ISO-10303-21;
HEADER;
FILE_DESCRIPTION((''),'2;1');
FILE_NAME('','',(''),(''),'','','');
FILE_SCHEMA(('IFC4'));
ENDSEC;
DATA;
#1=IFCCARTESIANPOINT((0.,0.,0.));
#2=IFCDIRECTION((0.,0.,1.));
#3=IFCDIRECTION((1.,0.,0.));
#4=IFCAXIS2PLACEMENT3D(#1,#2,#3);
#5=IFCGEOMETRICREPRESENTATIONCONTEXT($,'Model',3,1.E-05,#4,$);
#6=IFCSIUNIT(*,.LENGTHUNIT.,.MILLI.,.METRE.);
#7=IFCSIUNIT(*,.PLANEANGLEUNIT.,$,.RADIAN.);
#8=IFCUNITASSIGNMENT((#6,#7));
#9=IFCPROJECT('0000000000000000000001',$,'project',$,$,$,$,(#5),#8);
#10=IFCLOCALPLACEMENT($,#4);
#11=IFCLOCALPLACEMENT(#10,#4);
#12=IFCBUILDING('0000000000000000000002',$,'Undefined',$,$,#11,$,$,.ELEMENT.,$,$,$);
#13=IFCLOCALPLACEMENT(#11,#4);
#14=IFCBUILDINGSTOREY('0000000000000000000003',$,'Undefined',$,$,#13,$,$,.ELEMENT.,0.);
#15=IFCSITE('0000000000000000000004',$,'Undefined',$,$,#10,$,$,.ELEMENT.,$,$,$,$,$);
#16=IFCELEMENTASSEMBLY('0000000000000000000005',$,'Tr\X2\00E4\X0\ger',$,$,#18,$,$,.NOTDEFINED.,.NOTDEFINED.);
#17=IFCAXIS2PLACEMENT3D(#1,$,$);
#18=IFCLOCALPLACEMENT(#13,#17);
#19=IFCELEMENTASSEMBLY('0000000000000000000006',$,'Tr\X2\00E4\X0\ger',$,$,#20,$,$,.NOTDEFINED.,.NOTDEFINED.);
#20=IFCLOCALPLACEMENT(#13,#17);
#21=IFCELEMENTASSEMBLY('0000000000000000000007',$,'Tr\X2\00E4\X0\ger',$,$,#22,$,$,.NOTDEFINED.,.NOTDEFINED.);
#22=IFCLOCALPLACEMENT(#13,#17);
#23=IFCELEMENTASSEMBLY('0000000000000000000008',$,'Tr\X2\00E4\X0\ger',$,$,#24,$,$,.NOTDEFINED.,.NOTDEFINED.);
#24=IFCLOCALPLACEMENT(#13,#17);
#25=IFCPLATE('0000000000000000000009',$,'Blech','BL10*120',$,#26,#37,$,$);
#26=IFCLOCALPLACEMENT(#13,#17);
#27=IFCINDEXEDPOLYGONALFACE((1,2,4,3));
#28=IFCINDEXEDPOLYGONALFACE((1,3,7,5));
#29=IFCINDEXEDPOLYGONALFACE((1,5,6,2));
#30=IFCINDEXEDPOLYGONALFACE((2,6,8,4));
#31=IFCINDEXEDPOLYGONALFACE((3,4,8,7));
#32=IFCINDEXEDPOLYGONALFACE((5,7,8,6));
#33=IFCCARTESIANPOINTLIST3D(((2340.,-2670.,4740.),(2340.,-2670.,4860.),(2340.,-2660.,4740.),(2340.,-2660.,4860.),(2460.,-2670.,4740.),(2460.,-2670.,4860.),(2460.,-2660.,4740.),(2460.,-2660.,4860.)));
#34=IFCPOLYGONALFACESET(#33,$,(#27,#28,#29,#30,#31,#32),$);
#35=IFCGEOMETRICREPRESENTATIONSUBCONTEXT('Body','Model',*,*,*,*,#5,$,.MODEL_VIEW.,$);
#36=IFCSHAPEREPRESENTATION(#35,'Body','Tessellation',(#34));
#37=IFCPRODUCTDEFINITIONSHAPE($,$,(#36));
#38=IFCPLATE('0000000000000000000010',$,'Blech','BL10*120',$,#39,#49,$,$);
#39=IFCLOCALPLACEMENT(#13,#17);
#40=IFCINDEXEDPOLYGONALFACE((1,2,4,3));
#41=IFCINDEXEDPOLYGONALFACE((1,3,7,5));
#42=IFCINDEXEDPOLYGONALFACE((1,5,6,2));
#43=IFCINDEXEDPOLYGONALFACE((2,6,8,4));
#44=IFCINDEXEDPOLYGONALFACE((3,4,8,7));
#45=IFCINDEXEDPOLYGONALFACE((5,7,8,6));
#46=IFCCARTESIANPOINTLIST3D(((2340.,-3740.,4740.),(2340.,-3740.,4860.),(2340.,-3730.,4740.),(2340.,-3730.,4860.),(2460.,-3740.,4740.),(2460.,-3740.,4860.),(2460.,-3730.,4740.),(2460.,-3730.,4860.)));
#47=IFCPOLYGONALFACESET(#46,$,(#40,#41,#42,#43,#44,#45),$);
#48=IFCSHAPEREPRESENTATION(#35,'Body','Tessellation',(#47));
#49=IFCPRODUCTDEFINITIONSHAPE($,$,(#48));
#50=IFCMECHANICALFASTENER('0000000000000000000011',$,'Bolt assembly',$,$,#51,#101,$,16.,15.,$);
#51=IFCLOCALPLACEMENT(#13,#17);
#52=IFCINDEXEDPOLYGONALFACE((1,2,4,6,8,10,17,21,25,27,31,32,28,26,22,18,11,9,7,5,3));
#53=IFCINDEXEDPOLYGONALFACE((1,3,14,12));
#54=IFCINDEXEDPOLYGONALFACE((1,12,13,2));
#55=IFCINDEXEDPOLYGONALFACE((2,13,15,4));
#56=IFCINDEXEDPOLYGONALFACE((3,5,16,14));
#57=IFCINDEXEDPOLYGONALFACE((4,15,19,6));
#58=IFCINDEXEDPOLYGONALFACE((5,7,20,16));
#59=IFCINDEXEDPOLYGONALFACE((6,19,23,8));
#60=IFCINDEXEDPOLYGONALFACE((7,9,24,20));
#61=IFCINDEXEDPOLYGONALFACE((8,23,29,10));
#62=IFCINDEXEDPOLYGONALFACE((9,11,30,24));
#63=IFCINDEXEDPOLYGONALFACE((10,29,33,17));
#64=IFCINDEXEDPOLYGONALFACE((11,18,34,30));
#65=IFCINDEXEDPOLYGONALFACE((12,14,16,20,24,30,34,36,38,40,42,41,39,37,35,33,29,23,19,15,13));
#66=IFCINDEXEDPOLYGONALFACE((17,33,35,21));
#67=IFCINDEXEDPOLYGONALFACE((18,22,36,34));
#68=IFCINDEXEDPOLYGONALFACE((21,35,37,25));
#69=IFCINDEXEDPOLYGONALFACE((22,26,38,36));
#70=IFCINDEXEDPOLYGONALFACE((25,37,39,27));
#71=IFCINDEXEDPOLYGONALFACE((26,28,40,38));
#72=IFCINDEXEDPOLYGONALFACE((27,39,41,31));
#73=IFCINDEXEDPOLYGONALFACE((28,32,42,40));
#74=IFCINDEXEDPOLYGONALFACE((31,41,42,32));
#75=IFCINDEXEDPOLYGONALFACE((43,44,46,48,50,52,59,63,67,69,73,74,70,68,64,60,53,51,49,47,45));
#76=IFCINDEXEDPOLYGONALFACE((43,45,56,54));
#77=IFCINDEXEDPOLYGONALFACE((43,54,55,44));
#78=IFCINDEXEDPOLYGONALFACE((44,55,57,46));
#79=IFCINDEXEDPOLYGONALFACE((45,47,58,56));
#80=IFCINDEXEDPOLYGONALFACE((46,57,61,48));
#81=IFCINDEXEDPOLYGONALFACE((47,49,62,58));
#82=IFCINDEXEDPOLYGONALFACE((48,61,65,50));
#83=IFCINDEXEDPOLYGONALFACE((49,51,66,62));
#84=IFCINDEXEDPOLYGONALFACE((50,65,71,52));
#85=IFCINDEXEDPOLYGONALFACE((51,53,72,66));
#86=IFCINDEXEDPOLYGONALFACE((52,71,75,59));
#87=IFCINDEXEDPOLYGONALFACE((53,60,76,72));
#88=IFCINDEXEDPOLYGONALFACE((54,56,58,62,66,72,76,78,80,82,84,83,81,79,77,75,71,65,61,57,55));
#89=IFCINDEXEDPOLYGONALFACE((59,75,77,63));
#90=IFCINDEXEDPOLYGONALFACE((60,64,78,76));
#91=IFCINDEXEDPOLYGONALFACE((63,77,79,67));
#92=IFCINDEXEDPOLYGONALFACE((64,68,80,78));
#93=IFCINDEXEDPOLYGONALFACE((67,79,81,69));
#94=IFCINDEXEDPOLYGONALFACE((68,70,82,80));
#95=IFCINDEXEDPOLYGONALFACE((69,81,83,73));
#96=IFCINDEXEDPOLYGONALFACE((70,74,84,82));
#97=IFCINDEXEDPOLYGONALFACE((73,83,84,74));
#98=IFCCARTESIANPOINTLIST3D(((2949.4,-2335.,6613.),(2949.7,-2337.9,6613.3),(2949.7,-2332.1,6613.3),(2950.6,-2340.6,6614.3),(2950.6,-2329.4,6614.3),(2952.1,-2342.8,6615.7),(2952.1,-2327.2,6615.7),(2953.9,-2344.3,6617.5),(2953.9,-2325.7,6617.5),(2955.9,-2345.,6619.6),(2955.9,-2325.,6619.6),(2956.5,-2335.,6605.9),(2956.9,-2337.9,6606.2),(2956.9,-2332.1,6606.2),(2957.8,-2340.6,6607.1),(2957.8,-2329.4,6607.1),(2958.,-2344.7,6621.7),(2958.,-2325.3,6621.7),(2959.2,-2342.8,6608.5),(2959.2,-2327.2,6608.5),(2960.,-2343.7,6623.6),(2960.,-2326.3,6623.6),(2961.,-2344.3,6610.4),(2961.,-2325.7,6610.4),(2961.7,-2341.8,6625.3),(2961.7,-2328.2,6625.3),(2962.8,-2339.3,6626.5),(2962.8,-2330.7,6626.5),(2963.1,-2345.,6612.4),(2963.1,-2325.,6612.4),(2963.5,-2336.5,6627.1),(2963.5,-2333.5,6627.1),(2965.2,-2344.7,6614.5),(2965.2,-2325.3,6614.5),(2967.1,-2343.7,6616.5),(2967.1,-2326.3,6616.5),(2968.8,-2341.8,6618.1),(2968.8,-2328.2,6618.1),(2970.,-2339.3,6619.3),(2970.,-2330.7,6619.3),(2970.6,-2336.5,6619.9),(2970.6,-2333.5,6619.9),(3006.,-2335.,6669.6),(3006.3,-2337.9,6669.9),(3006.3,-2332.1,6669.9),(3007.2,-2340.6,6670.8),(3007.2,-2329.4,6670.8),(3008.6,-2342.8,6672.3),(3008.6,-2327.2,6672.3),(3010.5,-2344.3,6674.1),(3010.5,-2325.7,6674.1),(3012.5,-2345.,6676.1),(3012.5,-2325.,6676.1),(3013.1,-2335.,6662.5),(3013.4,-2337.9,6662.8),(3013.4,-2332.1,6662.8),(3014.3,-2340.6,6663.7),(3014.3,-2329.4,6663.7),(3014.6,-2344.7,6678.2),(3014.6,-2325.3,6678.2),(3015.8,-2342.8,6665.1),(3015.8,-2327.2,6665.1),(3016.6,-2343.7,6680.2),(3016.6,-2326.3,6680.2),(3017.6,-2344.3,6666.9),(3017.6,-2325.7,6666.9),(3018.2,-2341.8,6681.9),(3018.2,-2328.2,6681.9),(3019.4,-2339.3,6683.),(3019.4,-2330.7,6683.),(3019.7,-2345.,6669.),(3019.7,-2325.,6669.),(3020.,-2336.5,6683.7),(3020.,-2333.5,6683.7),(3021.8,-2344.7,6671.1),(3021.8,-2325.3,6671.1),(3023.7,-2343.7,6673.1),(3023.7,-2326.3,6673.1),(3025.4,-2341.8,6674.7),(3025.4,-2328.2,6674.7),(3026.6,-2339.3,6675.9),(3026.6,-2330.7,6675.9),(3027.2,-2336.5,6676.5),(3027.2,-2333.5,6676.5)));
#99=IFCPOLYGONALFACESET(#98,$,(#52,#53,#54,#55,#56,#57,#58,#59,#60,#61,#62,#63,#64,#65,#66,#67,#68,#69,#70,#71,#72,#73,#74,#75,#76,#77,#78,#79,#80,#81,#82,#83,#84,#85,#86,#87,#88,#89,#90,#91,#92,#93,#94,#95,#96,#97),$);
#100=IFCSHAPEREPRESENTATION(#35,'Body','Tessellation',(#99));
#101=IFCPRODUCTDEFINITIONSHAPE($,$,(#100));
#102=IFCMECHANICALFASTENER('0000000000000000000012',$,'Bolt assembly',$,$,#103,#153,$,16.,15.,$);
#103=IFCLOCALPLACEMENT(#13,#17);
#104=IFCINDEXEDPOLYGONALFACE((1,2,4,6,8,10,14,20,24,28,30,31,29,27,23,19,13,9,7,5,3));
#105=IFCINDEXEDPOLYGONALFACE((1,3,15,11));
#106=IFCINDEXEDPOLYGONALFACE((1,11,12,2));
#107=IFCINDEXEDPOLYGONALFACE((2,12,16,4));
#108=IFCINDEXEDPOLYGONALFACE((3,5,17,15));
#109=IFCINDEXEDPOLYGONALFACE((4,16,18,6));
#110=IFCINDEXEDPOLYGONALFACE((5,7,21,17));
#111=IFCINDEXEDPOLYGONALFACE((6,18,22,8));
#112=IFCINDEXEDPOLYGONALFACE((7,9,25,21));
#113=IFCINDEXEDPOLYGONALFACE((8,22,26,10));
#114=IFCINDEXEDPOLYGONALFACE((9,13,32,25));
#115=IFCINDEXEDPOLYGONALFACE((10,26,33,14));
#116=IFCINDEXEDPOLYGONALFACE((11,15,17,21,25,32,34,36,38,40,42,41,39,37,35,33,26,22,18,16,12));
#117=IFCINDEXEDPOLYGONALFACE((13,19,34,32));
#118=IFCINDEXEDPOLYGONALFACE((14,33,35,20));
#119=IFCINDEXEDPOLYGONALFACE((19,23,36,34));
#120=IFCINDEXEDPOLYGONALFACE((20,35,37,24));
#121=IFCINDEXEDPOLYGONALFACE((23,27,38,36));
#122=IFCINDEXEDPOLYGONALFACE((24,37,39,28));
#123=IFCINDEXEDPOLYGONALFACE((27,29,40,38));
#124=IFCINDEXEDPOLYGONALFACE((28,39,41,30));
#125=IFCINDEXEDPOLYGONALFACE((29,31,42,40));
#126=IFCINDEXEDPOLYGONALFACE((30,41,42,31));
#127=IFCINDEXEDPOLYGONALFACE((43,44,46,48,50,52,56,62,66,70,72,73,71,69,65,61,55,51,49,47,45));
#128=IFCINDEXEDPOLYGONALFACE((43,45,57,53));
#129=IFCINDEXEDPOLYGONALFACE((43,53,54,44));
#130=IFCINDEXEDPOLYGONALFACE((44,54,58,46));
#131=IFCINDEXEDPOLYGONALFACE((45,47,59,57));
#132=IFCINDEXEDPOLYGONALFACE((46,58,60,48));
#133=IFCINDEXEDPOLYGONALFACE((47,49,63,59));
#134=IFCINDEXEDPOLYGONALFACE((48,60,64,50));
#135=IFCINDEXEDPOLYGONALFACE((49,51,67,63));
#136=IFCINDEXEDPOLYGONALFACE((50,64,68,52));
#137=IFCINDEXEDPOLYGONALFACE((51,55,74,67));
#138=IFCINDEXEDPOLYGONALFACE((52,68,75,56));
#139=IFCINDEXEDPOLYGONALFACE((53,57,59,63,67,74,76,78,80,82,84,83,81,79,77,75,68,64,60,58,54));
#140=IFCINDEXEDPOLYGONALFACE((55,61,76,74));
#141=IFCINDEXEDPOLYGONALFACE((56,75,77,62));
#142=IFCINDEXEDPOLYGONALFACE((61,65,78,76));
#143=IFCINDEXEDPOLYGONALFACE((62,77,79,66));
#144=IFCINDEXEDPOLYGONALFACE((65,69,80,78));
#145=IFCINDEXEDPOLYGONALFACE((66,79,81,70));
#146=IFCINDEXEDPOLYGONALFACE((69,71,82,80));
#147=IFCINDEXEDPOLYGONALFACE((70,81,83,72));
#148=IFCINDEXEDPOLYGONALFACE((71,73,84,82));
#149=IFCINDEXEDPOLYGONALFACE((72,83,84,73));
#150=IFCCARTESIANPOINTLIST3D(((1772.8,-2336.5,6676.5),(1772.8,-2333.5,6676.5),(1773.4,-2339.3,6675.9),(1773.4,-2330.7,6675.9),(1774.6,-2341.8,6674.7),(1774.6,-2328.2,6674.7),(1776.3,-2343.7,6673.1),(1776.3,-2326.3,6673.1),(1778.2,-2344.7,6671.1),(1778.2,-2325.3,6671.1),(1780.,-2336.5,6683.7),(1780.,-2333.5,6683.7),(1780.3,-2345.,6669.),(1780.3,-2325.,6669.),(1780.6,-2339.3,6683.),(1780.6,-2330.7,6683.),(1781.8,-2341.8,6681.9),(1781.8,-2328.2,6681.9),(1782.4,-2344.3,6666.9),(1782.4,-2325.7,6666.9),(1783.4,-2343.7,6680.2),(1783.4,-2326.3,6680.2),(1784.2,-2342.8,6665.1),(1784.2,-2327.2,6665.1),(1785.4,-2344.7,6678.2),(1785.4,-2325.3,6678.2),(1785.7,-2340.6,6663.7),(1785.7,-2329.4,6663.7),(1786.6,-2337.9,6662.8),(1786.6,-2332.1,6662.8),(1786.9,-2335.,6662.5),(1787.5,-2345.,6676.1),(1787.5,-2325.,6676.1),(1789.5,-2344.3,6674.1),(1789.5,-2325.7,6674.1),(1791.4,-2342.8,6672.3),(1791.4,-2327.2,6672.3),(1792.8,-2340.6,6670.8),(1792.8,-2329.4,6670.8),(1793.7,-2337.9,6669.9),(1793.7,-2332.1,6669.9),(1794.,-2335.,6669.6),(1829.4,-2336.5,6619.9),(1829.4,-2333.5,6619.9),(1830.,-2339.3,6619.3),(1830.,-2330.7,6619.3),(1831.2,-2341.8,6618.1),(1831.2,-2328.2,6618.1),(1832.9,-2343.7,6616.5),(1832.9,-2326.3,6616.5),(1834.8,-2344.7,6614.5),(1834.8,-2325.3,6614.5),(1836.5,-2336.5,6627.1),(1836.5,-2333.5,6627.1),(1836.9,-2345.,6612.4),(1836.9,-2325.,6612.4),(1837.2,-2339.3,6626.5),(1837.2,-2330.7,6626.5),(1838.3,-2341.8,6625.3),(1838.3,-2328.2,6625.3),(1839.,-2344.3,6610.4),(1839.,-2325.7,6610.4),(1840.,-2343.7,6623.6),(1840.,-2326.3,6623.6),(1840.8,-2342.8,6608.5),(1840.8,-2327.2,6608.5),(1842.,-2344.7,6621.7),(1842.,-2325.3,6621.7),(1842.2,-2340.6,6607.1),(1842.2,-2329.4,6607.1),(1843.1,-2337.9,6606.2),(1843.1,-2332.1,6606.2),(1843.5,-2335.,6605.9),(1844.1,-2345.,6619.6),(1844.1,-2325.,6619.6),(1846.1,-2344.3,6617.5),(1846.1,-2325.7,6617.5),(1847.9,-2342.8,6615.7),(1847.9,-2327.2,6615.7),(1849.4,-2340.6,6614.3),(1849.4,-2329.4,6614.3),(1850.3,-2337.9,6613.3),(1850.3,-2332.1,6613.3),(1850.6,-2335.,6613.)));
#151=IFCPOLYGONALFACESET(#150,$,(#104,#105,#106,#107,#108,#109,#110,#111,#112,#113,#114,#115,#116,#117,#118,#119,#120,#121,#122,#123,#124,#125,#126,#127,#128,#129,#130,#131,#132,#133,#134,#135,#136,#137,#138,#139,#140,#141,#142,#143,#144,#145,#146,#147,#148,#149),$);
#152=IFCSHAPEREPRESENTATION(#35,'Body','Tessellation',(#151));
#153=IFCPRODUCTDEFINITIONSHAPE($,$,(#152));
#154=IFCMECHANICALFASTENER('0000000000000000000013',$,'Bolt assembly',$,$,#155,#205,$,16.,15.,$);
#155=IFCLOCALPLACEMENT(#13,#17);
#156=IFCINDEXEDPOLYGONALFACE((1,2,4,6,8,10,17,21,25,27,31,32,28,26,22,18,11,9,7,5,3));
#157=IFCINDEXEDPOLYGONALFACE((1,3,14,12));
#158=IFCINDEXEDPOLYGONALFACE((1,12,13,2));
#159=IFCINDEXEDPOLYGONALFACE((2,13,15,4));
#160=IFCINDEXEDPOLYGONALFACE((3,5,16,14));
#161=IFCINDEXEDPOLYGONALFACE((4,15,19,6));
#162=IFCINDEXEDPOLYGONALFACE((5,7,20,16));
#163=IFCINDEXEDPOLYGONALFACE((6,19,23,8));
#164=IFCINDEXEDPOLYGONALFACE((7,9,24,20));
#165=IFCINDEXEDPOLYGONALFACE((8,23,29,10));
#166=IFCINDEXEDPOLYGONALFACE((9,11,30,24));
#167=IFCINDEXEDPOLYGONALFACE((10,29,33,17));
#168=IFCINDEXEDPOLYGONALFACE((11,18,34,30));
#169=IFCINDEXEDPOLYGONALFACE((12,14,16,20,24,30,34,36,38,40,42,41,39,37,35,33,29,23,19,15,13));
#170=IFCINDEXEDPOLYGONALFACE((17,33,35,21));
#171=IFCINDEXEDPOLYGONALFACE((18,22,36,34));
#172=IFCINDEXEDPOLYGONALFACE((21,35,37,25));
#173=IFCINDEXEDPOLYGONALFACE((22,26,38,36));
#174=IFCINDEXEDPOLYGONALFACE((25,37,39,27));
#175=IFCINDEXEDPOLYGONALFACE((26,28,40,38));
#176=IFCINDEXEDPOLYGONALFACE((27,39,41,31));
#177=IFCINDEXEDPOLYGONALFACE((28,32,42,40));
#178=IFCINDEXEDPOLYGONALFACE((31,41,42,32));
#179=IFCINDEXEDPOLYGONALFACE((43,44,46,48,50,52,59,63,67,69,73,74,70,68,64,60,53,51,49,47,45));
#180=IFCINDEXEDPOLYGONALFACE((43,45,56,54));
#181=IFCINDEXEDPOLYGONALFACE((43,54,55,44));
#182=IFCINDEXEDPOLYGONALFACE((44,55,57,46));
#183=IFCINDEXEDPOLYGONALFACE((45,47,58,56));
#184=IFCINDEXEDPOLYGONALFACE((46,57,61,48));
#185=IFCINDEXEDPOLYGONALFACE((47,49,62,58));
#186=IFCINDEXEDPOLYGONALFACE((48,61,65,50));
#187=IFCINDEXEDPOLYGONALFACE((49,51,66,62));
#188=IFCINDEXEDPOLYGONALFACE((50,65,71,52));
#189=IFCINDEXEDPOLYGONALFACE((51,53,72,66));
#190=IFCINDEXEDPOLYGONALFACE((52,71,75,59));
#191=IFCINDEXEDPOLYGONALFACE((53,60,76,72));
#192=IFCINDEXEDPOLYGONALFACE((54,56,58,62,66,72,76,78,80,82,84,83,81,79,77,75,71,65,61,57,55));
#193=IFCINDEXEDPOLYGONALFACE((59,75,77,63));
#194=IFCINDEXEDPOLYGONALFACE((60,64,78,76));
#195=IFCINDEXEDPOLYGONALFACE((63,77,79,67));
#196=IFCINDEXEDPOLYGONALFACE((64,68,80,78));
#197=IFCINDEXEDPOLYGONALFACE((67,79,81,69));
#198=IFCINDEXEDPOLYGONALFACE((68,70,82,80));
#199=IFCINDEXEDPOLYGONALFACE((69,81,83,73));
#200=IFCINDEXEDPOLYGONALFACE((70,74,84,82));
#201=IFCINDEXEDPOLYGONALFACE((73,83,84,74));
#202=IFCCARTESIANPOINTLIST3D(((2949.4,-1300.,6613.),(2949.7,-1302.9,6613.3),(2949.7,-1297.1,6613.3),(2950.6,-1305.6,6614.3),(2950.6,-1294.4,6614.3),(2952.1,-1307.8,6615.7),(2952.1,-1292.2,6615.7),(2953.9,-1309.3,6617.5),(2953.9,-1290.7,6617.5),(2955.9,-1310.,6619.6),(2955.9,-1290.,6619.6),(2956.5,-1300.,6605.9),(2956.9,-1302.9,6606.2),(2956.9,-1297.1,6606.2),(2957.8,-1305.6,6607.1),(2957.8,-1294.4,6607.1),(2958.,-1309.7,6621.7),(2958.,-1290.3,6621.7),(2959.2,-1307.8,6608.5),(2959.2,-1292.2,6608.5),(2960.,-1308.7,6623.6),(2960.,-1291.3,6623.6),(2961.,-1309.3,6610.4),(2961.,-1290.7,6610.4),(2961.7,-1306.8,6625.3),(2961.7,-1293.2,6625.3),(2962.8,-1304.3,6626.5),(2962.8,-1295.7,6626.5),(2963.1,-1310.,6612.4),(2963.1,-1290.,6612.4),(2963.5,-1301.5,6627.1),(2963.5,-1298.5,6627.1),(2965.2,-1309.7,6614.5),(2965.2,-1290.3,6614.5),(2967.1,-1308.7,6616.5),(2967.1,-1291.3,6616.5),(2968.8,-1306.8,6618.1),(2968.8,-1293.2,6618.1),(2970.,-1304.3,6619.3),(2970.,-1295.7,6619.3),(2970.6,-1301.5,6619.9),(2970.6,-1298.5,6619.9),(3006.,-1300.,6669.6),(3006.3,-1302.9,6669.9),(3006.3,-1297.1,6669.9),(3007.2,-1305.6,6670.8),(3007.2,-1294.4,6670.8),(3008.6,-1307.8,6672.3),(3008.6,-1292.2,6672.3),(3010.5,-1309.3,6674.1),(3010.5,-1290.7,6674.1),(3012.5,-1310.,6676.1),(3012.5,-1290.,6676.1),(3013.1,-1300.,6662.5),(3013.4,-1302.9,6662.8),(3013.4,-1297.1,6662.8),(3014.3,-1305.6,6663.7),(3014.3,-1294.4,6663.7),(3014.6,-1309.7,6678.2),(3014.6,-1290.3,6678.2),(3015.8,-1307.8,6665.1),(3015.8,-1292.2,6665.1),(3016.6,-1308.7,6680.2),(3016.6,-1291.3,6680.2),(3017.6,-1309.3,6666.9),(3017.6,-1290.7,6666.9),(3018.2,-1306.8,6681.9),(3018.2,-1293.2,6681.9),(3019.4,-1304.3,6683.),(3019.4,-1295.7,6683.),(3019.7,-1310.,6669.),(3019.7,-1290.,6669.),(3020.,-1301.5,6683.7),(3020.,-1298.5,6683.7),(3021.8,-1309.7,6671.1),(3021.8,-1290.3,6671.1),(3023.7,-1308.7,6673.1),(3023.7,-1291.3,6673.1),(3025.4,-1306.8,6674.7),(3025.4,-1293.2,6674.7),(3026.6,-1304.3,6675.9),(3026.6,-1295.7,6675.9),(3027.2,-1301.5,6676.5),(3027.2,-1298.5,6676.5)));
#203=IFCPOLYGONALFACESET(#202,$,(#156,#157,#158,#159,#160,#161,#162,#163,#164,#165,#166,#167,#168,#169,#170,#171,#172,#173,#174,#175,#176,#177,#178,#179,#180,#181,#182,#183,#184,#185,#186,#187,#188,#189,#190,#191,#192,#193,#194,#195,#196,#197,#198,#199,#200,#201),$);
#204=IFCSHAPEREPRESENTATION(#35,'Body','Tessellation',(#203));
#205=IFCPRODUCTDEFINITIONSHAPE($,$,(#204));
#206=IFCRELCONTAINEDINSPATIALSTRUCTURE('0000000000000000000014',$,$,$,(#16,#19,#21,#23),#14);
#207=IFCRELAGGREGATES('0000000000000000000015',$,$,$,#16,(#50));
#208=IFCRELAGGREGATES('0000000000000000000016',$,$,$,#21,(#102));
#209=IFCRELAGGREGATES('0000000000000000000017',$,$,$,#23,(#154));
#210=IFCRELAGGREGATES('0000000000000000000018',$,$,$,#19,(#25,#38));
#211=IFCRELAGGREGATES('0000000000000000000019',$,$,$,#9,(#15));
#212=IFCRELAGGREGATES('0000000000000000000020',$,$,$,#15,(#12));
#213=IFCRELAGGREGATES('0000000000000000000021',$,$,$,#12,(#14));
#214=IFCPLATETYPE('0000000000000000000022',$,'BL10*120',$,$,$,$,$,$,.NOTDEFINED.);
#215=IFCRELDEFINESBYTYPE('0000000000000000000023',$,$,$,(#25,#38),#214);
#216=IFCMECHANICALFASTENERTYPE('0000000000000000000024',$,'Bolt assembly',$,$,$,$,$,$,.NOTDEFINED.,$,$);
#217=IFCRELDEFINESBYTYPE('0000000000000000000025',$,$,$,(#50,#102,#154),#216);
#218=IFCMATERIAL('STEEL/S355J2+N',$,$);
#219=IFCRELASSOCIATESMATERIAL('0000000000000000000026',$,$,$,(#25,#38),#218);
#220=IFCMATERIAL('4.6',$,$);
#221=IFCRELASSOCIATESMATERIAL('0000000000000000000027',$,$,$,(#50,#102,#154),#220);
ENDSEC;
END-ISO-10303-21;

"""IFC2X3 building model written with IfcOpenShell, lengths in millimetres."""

from ifc_helpers import new_model, si_unit, frame, origin_with_axes, origin_2d_with_axis, place, context, subcontext, project, spatial, polyline, circle, outline, extrude, source, transform, mapped, material, type_object, element, aggregate, save


model = new_model("IFC2X3")

# Units and contexts
model_context = context("Model", 3, precision=1e-05, world=origin_with_axes())
body_context = subcontext(model_context, "Body", "Model", "MODEL_VIEW")
ifc_project = project(units=[si_unit("LENGTHUNIT", "METRE", prefix="MILLI"), si_unit("PLANEANGLEUNIT", "RADIAN")], contexts=[model_context])

# Site, building, storey
site_placement = place(None, origin_with_axes())
site = spatial("IfcSite", under=ifc_project, at=site_placement, Name="Undefined", CompositionType="ELEMENT")
building_placement = place(site_placement, origin_with_axes())
building = spatial("IfcBuilding", under=site, at=building_placement, Name="Undefined", CompositionType="ELEMENT")
storey_placement = place(building_placement, origin_with_axes())
storey = spatial("IfcBuildingStorey", under=building, at=storey_placement, Name="Undefined", CompositionType="ELEMENT", Elevation=0.0)

# Element assembly
assembly_1_placement = place(storey_placement, origin_with_axes())
assembly_1 = element("IfcElementAssembly", 1, at=assembly_1_placement, inside=storey, Name="Träger", AssemblyPlace="NOTDEFINED", PredefinedType="NOTDEFINED")

# Element assembly
assembly_2_placement = place(storey_placement, origin_with_axes())
assembly_2 = element("IfcElementAssembly", 2, at=assembly_2_placement, inside=storey, Name="Träger", AssemblyPlace="NOTDEFINED", PredefinedType="NOTDEFINED")

# Shared definitions
plate_type = type_object("IfcPlateType", Name="BL10*120", PredefinedType="NOTDEFINED")

# Element assemblies
assembly_3_placement = place(storey_placement, origin_with_axes())
assembly_3 = element("IfcElementAssembly", 3, at=assembly_3_placement, inside=storey, Name="Träger", AssemblyPlace="NOTDEFINED", PredefinedType="NOTDEFINED")
assembly_4_placement = place(storey_placement, origin_with_axes())
assembly_4 = element("IfcElementAssembly", 4, at=assembly_4_placement, inside=storey, Name="Träger", AssemblyPlace="NOTDEFINED", PredefinedType="NOTDEFINED")

# Plates
ifc_material_1 = material(Name="STEEL/S355J2+N")
plate_1_placement = place(assembly_2_placement, frame((2400.0, -2665.0, 4740.0), z_axis=(0.0, -1.0, 0.0), x_axis=(0.0, 0.0, 1.0)))
plate_1 = element("IfcPlate", 5, at=plate_1_placement, type_object=plate_type, material=ifc_material_1, Name="Blech", Description="BL10*120", context=body_context, shape_type="SweptSolid", body=[
    extrude(outline(polyline([(0.0, -60.0), (0.0, 60.0), (120.0, 60.0), (120.0, -60.0), (0.0, -60.0)])), frame((0.0, 0.0, -5.0), z_axis=(0.0, 0.0, 1.0), x_axis=(1.0, 0.0, 0.0)), (0.0, 0.0, 1.0), 10.0),
])
plate_2_placement = place(assembly_2_placement, frame((2400.0, -3735.0, 4740.0), z_axis=(0.0, 1.0, 0.0), x_axis=(0.0, 0.0, 1.0)))
plate_2 = element("IfcPlate", 6, at=plate_2_placement, type_object=plate_type, material=ifc_material_1, Name="Blech", Description="BL10*120", context=body_context, shape_type="SweptSolid", body=[
    extrude(outline(polyline([(0.0, -60.0), (0.0, 60.0), (120.0, 60.0), (120.0, -60.0), (0.0, -60.0)])), frame((0.0, 0.0, -5.0), z_axis=(0.0, 0.0, 1.0), x_axis=(1.0, 0.0, 0.0)), (0.0, 0.0, 1.0), 10.0),
])

# Mechanical fasteners
ifc_material_2 = material(Name="4.6")
mechanical_fastener_type = type_object("IfcMechanicalFastenerType", Name="Bolt assembly")
shared_shape_1 = source(origin_with_axes(), body_context, "Body", "SweptSolid", [
    extrude(circle(Radius=10.0, at=origin_2d_with_axis()), frame((0.0, 0.0, 0.0), z_axis=(0.0, 1.0, 0.0), x_axis=(1.0, 0.0, 0.0)), (0.0, 0.0, 1.0), 10.1),
])
mechanical_fastener_1_placement = place(assembly_1_placement, frame((3013.0, -2335.0, 6676.7), z_axis=(0.0, -1.0, 0.0), x_axis=(-0.707107, 0.0, -0.707107)))
mechanical_fastener_1 = element("IfcMechanicalFastener", 7, at=mechanical_fastener_1_placement, type_object=mechanical_fastener_type, material=ifc_material_2, Name="Bolt assembly", NominalDiameter=16.0, NominalLength=15.0, context=body_context, shape_type="MappedRepresentation", body=[
    mapped(shared_shape_1, transform((0.0, 0.0, 0.0))),
    mapped(shared_shape_1, transform((80.0, 0.0, 0.0))),
])
aggregate(assembly_1, [mechanical_fastener_1])
mechanical_fastener_2_placement = place(assembly_3_placement, frame((1787.0, -2335.0, 6676.7), z_axis=(0.0, 1.0, 0.0), x_axis=(0.707107, 0.0, -0.707107)))
mechanical_fastener_2 = element("IfcMechanicalFastener", 8, at=mechanical_fastener_2_placement, type_object=mechanical_fastener_type, material=ifc_material_2, Name="Bolt assembly", NominalDiameter=16.0, NominalLength=15.0, context=body_context, shape_type="MappedRepresentation", body=[
    mapped(shared_shape_1, transform((0.0, 0.0, 0.0))),
    mapped(shared_shape_1, transform((80.0, 0.0, 0.0))),
])
aggregate(assembly_3, [mechanical_fastener_2])
mechanical_fastener_3_placement = place(assembly_4_placement, frame((3013.0, -1300.0, 6676.7), z_axis=(0.0, -1.0, 0.0), x_axis=(-0.707107, 0.0, -0.707107)))
mechanical_fastener_3 = element("IfcMechanicalFastener", 9, at=mechanical_fastener_3_placement, type_object=mechanical_fastener_type, material=ifc_material_2, Name="Bolt assembly", NominalDiameter=16.0, NominalLength=15.0, context=body_context, shape_type="MappedRepresentation", body=[
    mapped(shared_shape_1, transform((0.0, 0.0, 0.0))),
    mapped(shared_shape_1, transform((80.0, 0.0, 0.0))),
])
aggregate(assembly_4, [mechanical_fastener_3])

aggregate(assembly_2, [plate_1, plate_2])

save(model, "model.ifc")
